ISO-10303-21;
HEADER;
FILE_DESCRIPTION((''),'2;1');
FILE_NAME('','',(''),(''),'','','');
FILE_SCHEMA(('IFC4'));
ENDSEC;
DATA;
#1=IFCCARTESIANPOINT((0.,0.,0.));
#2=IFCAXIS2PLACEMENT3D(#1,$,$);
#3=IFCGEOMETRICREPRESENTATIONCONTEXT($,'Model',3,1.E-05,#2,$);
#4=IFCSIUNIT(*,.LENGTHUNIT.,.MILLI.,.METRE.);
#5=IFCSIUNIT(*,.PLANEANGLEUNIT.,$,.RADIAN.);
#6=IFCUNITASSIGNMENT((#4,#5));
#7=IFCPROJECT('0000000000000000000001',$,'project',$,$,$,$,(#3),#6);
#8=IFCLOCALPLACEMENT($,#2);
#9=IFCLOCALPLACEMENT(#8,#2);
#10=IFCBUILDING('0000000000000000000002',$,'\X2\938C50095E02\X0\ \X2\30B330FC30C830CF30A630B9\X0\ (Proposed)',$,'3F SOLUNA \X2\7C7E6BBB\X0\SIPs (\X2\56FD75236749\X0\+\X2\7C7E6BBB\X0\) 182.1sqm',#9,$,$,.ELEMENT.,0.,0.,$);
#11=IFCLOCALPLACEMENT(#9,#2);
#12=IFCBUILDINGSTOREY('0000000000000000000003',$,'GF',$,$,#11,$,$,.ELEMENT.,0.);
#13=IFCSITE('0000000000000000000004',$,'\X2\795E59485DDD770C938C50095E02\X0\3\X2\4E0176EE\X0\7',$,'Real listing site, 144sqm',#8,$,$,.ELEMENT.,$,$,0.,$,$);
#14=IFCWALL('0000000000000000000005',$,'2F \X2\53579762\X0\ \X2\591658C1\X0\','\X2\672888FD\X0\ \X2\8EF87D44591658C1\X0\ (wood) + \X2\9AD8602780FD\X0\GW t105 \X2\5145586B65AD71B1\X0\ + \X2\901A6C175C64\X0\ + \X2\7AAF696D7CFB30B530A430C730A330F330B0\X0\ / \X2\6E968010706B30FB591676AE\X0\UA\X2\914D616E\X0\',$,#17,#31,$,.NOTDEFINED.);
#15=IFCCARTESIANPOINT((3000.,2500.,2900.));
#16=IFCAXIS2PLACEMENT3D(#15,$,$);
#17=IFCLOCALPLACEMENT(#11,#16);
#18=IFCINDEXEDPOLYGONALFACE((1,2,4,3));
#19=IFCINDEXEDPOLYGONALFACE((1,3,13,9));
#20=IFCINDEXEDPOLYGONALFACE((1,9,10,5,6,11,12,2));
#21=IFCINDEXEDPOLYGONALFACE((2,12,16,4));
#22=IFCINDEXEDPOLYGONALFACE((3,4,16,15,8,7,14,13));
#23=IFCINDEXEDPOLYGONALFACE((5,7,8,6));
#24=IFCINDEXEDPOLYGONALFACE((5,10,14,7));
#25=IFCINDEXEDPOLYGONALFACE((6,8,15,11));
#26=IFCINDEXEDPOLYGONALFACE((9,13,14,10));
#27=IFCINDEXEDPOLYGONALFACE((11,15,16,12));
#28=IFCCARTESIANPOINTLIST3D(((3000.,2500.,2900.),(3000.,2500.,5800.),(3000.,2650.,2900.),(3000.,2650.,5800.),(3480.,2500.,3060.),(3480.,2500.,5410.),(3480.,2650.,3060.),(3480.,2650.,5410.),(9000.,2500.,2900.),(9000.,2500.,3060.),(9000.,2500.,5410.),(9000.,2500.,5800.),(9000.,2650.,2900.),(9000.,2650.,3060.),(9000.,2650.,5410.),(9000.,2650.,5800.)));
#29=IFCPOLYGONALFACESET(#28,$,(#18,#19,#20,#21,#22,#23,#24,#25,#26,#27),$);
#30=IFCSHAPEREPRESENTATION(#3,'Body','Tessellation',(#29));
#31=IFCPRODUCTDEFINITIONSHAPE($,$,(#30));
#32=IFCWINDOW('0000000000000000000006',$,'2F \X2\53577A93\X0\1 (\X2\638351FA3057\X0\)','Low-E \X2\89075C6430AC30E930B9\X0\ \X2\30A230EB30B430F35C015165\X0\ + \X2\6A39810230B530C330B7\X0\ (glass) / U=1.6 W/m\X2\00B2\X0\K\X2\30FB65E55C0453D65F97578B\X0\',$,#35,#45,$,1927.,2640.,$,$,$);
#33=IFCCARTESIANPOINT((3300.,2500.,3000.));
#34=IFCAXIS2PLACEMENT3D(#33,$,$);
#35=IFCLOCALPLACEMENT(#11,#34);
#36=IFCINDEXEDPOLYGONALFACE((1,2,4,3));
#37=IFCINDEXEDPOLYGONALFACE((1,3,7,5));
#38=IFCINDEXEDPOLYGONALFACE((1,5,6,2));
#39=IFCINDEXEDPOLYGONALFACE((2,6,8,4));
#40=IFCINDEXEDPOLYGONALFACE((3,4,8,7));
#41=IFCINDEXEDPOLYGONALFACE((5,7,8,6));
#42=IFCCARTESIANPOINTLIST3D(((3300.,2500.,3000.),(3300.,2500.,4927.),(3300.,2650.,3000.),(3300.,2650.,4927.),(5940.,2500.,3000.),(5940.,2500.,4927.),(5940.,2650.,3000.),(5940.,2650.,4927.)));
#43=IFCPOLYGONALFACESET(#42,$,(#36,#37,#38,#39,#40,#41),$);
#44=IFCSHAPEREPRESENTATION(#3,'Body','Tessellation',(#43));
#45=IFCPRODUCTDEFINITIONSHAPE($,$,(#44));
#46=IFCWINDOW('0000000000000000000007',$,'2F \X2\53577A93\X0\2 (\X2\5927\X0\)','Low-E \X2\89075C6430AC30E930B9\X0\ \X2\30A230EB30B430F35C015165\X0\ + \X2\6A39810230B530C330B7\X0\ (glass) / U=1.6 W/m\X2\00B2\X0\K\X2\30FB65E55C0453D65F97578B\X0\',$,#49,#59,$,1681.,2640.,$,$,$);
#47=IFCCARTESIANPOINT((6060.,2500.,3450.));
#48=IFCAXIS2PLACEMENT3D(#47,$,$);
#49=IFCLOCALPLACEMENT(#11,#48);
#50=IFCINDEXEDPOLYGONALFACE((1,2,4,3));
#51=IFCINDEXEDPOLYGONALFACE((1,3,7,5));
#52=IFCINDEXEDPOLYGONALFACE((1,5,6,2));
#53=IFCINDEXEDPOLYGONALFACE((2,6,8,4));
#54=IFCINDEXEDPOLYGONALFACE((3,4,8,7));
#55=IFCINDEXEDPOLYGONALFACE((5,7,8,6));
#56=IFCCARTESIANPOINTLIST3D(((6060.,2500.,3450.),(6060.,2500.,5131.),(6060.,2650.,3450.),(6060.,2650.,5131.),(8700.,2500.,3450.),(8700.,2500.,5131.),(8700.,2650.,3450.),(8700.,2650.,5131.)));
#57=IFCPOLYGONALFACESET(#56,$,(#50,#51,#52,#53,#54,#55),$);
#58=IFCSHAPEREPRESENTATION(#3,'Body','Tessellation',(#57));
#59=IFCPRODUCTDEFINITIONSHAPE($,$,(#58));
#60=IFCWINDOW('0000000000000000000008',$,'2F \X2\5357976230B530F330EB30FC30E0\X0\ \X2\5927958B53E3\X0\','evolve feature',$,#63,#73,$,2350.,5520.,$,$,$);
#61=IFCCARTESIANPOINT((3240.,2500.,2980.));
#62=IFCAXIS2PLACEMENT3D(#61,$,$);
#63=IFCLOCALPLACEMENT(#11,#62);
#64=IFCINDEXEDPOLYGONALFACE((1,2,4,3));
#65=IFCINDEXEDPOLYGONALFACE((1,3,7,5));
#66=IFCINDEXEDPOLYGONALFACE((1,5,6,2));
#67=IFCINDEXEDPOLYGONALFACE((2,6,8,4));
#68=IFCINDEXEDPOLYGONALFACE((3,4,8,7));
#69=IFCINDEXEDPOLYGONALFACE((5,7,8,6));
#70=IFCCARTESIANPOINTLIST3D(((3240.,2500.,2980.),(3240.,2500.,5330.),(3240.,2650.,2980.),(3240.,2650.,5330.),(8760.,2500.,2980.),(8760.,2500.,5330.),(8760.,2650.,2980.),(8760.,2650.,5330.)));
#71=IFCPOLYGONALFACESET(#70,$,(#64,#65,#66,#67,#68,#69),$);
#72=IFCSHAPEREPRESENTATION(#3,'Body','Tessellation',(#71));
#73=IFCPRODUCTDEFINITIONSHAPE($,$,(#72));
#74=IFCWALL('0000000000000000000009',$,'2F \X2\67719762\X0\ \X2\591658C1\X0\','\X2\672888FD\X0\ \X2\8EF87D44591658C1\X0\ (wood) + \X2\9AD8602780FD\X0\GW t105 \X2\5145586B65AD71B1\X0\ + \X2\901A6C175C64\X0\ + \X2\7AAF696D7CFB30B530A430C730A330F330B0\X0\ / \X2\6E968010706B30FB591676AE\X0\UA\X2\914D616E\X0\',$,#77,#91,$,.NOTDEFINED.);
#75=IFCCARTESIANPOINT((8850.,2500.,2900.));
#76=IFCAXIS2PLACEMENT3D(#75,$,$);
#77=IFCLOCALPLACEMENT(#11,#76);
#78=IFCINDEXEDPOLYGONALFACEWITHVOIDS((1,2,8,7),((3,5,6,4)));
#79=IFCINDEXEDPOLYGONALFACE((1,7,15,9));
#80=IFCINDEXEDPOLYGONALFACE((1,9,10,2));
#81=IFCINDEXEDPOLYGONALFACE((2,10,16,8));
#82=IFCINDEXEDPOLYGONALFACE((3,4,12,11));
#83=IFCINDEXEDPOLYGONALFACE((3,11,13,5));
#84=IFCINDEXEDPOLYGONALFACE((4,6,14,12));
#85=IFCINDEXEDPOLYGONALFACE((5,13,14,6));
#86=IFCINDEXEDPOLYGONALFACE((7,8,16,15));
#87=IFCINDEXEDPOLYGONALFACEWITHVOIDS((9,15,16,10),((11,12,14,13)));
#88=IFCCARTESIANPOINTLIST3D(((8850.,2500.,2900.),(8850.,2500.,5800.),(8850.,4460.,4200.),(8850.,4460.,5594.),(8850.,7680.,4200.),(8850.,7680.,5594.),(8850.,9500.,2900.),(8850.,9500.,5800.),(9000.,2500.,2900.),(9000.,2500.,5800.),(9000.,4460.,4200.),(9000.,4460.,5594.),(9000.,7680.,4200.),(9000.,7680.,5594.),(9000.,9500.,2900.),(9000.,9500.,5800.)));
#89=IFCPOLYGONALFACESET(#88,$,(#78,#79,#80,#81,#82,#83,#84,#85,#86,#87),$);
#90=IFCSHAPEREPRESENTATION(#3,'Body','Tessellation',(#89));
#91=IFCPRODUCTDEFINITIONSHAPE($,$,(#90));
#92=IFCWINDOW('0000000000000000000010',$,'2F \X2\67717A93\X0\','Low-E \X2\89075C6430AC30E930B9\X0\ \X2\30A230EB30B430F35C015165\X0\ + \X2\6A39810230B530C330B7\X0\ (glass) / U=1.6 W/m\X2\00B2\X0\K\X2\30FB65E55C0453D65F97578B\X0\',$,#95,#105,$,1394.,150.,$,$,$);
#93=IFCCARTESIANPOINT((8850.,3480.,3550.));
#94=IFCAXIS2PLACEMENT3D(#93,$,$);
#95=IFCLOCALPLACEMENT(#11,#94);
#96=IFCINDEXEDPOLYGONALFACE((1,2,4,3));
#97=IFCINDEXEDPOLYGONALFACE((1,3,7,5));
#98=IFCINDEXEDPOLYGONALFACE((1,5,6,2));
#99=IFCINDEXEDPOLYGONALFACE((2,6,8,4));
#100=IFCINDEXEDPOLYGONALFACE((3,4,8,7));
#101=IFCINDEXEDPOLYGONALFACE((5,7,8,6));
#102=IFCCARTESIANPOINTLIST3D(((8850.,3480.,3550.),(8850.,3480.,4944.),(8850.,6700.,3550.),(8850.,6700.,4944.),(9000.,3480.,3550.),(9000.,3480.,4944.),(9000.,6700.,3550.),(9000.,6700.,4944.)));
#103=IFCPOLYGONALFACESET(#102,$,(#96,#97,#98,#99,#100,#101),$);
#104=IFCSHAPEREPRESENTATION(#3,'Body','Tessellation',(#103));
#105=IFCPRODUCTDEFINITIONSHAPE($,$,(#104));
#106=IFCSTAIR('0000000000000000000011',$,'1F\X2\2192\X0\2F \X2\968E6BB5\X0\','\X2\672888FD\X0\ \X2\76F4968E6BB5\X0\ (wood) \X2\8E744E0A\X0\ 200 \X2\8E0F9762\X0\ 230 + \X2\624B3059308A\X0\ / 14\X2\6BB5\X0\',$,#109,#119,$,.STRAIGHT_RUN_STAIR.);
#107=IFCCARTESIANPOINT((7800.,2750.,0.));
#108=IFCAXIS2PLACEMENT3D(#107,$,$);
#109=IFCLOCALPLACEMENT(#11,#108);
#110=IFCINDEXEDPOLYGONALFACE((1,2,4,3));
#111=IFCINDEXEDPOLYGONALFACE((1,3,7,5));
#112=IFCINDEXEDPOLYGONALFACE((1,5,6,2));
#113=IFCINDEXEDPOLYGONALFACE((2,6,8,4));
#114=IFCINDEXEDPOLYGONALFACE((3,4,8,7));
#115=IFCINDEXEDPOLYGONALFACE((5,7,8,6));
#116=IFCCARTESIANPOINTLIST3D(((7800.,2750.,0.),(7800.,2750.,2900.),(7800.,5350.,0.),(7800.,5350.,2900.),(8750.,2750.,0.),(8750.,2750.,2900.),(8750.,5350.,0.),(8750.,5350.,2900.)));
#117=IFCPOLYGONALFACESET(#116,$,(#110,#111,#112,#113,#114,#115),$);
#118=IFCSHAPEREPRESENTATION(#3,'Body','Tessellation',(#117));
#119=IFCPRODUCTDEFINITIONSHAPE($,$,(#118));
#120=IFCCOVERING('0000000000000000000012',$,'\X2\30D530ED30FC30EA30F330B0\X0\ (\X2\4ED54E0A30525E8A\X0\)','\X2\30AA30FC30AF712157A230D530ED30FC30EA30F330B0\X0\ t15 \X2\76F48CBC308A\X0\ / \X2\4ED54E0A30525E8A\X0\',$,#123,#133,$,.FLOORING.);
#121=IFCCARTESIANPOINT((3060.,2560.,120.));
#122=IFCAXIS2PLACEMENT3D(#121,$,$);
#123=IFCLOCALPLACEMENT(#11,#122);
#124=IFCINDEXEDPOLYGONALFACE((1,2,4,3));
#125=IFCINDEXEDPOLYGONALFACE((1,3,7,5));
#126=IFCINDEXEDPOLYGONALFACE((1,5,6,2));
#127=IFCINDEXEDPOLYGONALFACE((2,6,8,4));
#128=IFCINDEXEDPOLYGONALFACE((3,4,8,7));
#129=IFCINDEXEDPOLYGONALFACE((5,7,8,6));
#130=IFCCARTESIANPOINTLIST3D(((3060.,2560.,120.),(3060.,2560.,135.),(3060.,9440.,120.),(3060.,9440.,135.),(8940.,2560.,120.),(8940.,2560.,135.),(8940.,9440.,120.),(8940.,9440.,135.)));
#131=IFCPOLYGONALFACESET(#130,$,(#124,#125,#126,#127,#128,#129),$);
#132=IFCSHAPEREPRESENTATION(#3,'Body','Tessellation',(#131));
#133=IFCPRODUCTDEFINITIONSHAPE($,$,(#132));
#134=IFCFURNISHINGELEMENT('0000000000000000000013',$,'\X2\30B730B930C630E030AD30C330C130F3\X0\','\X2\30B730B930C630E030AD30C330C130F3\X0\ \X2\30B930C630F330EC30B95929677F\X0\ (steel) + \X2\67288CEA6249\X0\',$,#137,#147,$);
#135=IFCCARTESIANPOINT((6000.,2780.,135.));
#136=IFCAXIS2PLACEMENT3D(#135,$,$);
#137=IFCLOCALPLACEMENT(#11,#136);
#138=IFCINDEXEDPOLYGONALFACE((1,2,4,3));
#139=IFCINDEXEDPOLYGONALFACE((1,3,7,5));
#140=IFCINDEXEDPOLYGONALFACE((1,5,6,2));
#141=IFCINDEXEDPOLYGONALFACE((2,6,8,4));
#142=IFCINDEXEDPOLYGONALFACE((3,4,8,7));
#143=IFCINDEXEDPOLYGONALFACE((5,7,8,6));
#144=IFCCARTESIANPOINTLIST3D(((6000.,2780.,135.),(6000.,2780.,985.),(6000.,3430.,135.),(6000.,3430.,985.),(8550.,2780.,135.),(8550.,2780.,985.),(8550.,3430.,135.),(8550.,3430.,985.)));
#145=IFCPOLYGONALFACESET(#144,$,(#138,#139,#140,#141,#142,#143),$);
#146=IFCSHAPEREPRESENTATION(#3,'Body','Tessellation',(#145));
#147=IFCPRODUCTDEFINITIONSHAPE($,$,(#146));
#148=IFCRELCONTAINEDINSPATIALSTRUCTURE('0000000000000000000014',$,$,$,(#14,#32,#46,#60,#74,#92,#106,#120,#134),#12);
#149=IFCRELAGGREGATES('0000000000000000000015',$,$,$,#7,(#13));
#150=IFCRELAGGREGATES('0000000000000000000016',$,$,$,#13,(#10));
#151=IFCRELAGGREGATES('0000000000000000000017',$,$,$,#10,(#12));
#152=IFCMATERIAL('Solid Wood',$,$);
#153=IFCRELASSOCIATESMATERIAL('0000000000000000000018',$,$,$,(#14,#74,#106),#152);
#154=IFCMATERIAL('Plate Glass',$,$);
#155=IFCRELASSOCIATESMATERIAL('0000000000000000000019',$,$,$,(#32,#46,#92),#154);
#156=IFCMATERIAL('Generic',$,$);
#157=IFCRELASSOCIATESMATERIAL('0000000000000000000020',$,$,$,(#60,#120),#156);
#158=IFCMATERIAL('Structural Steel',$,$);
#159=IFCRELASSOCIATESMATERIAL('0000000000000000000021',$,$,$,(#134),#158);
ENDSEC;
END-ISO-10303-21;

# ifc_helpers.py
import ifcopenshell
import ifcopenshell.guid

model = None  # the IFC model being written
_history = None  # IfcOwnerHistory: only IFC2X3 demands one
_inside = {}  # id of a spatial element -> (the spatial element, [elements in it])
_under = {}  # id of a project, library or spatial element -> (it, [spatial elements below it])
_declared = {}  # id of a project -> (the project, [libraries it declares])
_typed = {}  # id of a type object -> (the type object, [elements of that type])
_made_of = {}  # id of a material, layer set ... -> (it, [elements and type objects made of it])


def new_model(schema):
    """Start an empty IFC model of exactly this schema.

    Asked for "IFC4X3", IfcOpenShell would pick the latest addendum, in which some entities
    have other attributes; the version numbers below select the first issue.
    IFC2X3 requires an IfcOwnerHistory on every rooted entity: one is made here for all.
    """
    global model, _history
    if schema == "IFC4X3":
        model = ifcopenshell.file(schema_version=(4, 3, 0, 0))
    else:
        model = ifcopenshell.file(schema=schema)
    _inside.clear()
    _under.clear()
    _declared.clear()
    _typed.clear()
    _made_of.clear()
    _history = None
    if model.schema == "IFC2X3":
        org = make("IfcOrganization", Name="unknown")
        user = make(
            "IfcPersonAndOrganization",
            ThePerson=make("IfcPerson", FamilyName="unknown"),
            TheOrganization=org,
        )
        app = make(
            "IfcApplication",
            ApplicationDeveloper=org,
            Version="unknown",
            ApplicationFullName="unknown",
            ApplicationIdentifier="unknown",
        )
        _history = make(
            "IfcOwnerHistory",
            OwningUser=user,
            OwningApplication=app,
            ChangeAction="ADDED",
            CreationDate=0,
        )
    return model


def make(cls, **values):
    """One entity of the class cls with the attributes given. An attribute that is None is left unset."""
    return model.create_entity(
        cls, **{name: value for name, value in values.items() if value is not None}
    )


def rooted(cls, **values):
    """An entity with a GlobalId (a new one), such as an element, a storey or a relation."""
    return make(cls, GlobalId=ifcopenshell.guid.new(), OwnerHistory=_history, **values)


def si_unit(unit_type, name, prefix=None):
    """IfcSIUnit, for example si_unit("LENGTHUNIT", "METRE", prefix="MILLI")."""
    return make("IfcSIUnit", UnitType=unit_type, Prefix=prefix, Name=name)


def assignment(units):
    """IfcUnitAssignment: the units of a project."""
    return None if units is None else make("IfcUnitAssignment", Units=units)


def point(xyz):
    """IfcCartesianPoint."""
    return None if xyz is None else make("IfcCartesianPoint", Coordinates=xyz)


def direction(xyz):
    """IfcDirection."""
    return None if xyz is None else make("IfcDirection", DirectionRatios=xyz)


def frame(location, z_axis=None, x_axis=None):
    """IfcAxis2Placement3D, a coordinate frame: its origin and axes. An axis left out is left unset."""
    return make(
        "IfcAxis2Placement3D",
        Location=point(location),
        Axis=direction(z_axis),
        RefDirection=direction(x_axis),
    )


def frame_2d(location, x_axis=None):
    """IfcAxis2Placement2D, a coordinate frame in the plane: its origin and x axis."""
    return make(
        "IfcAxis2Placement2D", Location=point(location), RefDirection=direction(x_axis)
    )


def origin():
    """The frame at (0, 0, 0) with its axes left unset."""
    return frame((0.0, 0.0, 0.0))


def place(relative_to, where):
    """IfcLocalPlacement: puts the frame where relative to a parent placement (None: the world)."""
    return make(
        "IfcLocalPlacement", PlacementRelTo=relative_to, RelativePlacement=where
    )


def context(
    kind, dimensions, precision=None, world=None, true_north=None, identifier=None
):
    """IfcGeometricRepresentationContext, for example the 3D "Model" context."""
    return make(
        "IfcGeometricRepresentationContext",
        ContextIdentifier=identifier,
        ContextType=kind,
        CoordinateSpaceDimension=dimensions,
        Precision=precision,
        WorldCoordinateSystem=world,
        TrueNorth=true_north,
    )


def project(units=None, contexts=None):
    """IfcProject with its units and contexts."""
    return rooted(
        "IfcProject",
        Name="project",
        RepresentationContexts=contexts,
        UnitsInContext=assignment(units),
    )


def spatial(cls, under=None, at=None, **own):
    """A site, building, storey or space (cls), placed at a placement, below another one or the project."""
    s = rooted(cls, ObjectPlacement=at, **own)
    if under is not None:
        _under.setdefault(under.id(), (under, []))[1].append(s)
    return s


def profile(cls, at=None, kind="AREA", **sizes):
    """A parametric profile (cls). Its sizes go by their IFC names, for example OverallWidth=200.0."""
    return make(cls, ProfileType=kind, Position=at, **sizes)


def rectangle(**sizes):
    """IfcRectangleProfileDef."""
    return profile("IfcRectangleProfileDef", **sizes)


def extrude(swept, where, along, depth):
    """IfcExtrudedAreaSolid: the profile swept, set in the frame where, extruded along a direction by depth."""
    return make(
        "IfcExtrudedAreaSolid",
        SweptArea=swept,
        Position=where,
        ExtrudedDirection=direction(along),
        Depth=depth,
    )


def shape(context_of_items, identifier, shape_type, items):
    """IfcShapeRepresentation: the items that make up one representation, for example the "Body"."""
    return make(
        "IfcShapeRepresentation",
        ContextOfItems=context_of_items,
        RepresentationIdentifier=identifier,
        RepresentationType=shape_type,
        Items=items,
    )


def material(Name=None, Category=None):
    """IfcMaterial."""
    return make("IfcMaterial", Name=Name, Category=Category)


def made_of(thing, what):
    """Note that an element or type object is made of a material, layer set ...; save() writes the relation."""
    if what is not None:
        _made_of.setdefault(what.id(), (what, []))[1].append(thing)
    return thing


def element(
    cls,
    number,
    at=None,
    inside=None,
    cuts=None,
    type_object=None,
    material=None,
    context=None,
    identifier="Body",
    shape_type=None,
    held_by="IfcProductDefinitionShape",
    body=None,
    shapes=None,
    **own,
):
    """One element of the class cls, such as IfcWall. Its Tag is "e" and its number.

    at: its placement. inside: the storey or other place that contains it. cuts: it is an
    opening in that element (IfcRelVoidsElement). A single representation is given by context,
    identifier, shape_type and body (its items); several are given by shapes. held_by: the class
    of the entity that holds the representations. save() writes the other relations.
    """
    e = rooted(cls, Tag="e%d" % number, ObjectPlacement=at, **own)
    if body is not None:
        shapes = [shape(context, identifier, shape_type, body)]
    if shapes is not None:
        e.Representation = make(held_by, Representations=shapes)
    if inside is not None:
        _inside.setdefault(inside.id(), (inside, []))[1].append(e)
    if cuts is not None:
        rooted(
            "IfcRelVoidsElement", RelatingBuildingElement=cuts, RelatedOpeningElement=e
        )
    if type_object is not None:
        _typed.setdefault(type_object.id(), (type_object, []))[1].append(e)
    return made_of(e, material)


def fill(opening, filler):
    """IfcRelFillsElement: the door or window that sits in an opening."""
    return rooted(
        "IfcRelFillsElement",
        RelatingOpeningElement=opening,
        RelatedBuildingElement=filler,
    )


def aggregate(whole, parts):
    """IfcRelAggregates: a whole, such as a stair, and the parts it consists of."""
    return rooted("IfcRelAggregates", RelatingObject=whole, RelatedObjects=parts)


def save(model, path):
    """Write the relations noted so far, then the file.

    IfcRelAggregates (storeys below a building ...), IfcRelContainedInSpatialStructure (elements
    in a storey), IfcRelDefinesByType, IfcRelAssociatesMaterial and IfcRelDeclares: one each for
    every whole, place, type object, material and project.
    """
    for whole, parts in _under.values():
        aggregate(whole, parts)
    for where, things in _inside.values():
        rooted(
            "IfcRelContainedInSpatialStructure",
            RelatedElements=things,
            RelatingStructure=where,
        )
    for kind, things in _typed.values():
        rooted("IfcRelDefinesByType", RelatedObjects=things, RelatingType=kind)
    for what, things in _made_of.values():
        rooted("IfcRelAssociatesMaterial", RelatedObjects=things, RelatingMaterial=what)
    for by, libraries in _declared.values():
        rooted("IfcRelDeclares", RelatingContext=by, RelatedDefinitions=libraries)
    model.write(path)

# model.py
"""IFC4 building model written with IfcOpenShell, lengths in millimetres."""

from ifc_helpers import new_model, si_unit, frame, frame_2d, origin, place, context, project, spatial, rectangle, extrude, material, element, fill, save


model = new_model("IFC4")

# Units and contexts
model_context = context("Model", 3, precision=1e-05, world=origin())
ifc_project = project(units=[si_unit("LENGTHUNIT", "METRE", prefix="MILLI"), si_unit("PLANEANGLEUNIT", "RADIAN")], contexts=[model_context])

# Site, building, storey
site_placement = place(None, origin())
site = spatial("IfcSite", under=ifc_project, at=site_placement, Name="神奈川県鎌倉市3丁目7", ObjectType="Real listing site, 144sqm", CompositionType="ELEMENT", RefElevation=0.0)
building_placement = place(site_placement, origin())
building = spatial("IfcBuilding", under=site, at=building_placement, Name="鎌倉市 コートハウス (Proposed)", ObjectType="3F SOLUNA 籾殻SIPs (国産杉+籾殻) 182.1sqm", CompositionType="ELEMENT", ElevationOfRefHeight=0.0, ElevationOfTerrain=0.0)
storey_placement = place(building_placement, origin())
storey = spatial("IfcBuildingStorey", under=building, at=storey_placement, Name="GF", CompositionType="ELEMENT", Elevation=0.0)

# Shared definitions
ifc_material_1 = material(Name="Solid Wood")

# Shared definitions
ifc_material_2 = material(Name="Plate Glass")
ifc_material_3 = material(Name="Generic")

# Wall, openings, windows
wall_1_placement = place(storey_placement, frame((3000.0, 2500.0, 2900.0)))
wall_1 = element("IfcWall", 1, at=wall_1_placement, inside=storey, material=ifc_material_1, Name="2F 南面 外壁", Description="木製 軸組外壁 (wood) + 高性能GW t105 充填断熱 + 通気層 + 窯業系サイディング / 準耐火・外皮UA配慮", PredefinedType="NOTDEFINED", context=model_context, shape_type="SweptSolid", body=[
    extrude(rectangle(XDim=6000.0, YDim=150.0, at=frame_2d((3000.0, 75.0))), frame((3000.0, 2500.0, 2900.0)), (0.0, 0.0, 1.0), 2900.0),
])
opening_1_placement = place(storey_placement, frame((3300.0, 2500.0, 3000.0)))
opening_1 = element("IfcOpeningElement", 2, at=opening_1_placement, cuts=wall_1, PredefinedType="NOTDEFINED", context=model_context, shape_type="SweptSolid", body=[
    extrude(rectangle(XDim=2640.0, YDim=150.0, at=frame_2d((1320.0, 75.0))), frame((3300.0, 2500.0, 3000.0)), (0.0, 0.0, 1.0), 1927.0),
])
opening_2_placement = place(storey_placement, frame((6060.0, 2500.0, 3450.0)))
opening_2 = element("IfcOpeningElement", 3, at=opening_2_placement, cuts=wall_1, PredefinedType="NOTDEFINED", context=model_context, shape_type="SweptSolid", body=[
    extrude(rectangle(XDim=2640.0, YDim=150.0, at=frame_2d((1320.0, 75.0))), frame((6060.0, 2500.0, 3450.0)), (0.0, 0.0, 1.0), 1681.0),
])
opening_3_placement = place(storey_placement, frame((3240.0, 2500.0, 2980.0)))
opening_3 = element("IfcOpeningElement", 4, at=opening_3_placement, cuts=wall_1, PredefinedType="NOTDEFINED", context=model_context, shape_type="SweptSolid", body=[
    extrude(rectangle(XDim=5520.0, YDim=150.0, at=frame_2d((2760.0, 75.0))), frame((3240.0, 2500.0, 2980.0)), (0.0, 0.0, 1.0), 2350.0),
])
window_1_placement = place(storey_placement, frame((3300.0, 2500.0, 3000.0)))
window_1 = element("IfcWindow", 5, at=window_1_placement, inside=storey, material=ifc_material_2, Name="2F 南窓1 (掃出し)", Description="Low-E 複層ガラス アルゴン封入 + 樹脂サッシ (glass) / U=1.6 W/m²K・日射取得型", OverallHeight=1927.0, OverallWidth=2640.0, context=model_context, shape_type="SweptSolid", body=[
    extrude(rectangle(XDim=2640.0, YDim=150.0, at=frame_2d((1320.0, 75.0))), frame((3300.0, 2500.0, 3000.0)), (0.0, 0.0, 1.0), 1927.0),
])
fill(opening_1, window_1)
window_2_placement = place(storey_placement, frame((6060.0, 2500.0, 3450.0)))
window_2 = element("IfcWindow", 6, at=window_2_placement, inside=storey, material=ifc_material_2, Name="2F 南窓2 (大)", Description="Low-E 複層ガラス アルゴン封入 + 樹脂サッシ (glass) / U=1.6 W/m²K・日射取得型", OverallHeight=1681.0, OverallWidth=2640.0, context=model_context, shape_type="SweptSolid", body=[
    extrude(rectangle(XDim=2640.0, YDim=150.0, at=frame_2d((1320.0, 75.0))), frame((6060.0, 2500.0, 3450.0)), (0.0, 0.0, 1.0), 1681.0),
])
fill(opening_2, window_2)
window_3_placement = place(storey_placement, frame((3240.0, 2500.0, 2980.0)))
window_3 = element("IfcWindow", 7, at=window_3_placement, inside=storey, material=ifc_material_3, Name="2F 南面サンルーム 大開口", Description="evolve feature", OverallHeight=2350.0, OverallWidth=5520.0, context=model_context, shape_type="SweptSolid", body=[
    extrude(rectangle(XDim=5520.0, YDim=150.0, at=frame_2d((2760.0, 75.0))), frame((3240.0, 2500.0, 2980.0)), (0.0, 0.0, 1.0), 2350.0),
])
fill(opening_3, window_3)

# Wall, opening, window
wall_2_placement = place(storey_placement, frame((8850.0, 2500.0, 2900.0)))
wall_2 = element("IfcWall", 8, at=wall_2_placement, inside=storey, material=ifc_material_1, Name="2F 東面 外壁", Description="木製 軸組外壁 (wood) + 高性能GW t105 充填断熱 + 通気層 + 窯業系サイディング / 準耐火・外皮UA配慮", PredefinedType="NOTDEFINED", context=model_context, shape_type="SweptSolid", body=[
    extrude(rectangle(XDim=150.0, YDim=7000.0, at=frame_2d((75.0, 3500.0))), frame((8850.0, 2500.0, 2900.0)), (0.0, 0.0, 1.0), 2900.0),
])
opening_4_placement = place(storey_placement, frame((8850.0, 3480.0, 3550.0)))
opening_4 = element("IfcOpeningElement", 9, at=opening_4_placement, cuts=wall_2, PredefinedType="NOTDEFINED", context=model_context, shape_type="SweptSolid", body=[
    extrude(rectangle(XDim=150.0, YDim=3220.0, at=frame_2d((75.0, 1610.0))), frame((8850.0, 3480.0, 3550.0)), (0.0, 0.0, 1.0), 1394.0),
])
window_4_placement = place(storey_placement, frame((8850.0, 3480.0, 3550.0)))
window_4 = element("IfcWindow", 10, at=window_4_placement, inside=storey, material=ifc_material_2, Name="2F 東窓", Description="Low-E 複層ガラス アルゴン封入 + 樹脂サッシ (glass) / U=1.6 W/m²K・日射取得型", OverallHeight=1394.0, OverallWidth=150.0, context=model_context, shape_type="SweptSolid", body=[
    extrude(rectangle(XDim=150.0, YDim=3220.0, at=frame_2d((75.0, 1610.0))), frame((8850.0, 3480.0, 3550.0)), (0.0, 0.0, 1.0), 1394.0),
])
fill(opening_4, window_4)

# Stair
stair_placement = place(storey_placement, frame((7800.0, 2750.0, 0.0)))
element("IfcStair", 11, at=stair_placement, inside=storey, material=ifc_material_1, Name="1F→2F 階段", Description="木製 直階段 (wood) 蹴上 200 踏面 230 + 手すり / 14段", PredefinedType="STRAIGHT_RUN_STAIR", context=model_context, shape_type="SweptSolid", body=[
    extrude(rectangle(XDim=950.0, YDim=2600.0, at=frame_2d((475.0, 1300.0))), frame((7800.0, 2750.0, 0.0)), (0.0, 0.0, 1.0), 2900.0),
])

# Covering
covering_placement = place(storey_placement, frame((3060.0, 2560.0, 120.0)))
element("IfcCovering", 12, at=covering_placement, inside=storey, material=ifc_material_3, Name="フローリング (仕上げ床)", Description="オーク無垢フローリング t15 直貼り / 仕上げ床", PredefinedType="FLOORING", context=model_context, shape_type="SweptSolid", body=[
    extrude(rectangle(XDim=5880.0, YDim=6880.0, at=frame_2d((2940.0, 3440.0))), frame((3060.0, 2560.0, 120.0)), (0.0, 0.0, 1.0), 15.0),
])

# Furnishing element
ifc_material_4 = material(Name="Structural Steel")
furnishing_placement = place(storey_placement, frame((6000.0, 2780.0, 135.0)))
element("IfcFurnishingElement", 13, at=furnishing_placement, inside=storey, material=ifc_material_4, Name="システムキッチン", Description="システムキッチン ステンレス天板 (steel) + 木質扉", context=model_context, shape_type="SweptSolid", body=[
    extrude(rectangle(XDim=2550.0, YDim=650.0, at=frame_2d((1275.0, 325.0))), frame((6000.0, 2780.0, 135.0)), (0.0, 0.0, 1.0), 850.0),
])

save(model, "model.ifc")
